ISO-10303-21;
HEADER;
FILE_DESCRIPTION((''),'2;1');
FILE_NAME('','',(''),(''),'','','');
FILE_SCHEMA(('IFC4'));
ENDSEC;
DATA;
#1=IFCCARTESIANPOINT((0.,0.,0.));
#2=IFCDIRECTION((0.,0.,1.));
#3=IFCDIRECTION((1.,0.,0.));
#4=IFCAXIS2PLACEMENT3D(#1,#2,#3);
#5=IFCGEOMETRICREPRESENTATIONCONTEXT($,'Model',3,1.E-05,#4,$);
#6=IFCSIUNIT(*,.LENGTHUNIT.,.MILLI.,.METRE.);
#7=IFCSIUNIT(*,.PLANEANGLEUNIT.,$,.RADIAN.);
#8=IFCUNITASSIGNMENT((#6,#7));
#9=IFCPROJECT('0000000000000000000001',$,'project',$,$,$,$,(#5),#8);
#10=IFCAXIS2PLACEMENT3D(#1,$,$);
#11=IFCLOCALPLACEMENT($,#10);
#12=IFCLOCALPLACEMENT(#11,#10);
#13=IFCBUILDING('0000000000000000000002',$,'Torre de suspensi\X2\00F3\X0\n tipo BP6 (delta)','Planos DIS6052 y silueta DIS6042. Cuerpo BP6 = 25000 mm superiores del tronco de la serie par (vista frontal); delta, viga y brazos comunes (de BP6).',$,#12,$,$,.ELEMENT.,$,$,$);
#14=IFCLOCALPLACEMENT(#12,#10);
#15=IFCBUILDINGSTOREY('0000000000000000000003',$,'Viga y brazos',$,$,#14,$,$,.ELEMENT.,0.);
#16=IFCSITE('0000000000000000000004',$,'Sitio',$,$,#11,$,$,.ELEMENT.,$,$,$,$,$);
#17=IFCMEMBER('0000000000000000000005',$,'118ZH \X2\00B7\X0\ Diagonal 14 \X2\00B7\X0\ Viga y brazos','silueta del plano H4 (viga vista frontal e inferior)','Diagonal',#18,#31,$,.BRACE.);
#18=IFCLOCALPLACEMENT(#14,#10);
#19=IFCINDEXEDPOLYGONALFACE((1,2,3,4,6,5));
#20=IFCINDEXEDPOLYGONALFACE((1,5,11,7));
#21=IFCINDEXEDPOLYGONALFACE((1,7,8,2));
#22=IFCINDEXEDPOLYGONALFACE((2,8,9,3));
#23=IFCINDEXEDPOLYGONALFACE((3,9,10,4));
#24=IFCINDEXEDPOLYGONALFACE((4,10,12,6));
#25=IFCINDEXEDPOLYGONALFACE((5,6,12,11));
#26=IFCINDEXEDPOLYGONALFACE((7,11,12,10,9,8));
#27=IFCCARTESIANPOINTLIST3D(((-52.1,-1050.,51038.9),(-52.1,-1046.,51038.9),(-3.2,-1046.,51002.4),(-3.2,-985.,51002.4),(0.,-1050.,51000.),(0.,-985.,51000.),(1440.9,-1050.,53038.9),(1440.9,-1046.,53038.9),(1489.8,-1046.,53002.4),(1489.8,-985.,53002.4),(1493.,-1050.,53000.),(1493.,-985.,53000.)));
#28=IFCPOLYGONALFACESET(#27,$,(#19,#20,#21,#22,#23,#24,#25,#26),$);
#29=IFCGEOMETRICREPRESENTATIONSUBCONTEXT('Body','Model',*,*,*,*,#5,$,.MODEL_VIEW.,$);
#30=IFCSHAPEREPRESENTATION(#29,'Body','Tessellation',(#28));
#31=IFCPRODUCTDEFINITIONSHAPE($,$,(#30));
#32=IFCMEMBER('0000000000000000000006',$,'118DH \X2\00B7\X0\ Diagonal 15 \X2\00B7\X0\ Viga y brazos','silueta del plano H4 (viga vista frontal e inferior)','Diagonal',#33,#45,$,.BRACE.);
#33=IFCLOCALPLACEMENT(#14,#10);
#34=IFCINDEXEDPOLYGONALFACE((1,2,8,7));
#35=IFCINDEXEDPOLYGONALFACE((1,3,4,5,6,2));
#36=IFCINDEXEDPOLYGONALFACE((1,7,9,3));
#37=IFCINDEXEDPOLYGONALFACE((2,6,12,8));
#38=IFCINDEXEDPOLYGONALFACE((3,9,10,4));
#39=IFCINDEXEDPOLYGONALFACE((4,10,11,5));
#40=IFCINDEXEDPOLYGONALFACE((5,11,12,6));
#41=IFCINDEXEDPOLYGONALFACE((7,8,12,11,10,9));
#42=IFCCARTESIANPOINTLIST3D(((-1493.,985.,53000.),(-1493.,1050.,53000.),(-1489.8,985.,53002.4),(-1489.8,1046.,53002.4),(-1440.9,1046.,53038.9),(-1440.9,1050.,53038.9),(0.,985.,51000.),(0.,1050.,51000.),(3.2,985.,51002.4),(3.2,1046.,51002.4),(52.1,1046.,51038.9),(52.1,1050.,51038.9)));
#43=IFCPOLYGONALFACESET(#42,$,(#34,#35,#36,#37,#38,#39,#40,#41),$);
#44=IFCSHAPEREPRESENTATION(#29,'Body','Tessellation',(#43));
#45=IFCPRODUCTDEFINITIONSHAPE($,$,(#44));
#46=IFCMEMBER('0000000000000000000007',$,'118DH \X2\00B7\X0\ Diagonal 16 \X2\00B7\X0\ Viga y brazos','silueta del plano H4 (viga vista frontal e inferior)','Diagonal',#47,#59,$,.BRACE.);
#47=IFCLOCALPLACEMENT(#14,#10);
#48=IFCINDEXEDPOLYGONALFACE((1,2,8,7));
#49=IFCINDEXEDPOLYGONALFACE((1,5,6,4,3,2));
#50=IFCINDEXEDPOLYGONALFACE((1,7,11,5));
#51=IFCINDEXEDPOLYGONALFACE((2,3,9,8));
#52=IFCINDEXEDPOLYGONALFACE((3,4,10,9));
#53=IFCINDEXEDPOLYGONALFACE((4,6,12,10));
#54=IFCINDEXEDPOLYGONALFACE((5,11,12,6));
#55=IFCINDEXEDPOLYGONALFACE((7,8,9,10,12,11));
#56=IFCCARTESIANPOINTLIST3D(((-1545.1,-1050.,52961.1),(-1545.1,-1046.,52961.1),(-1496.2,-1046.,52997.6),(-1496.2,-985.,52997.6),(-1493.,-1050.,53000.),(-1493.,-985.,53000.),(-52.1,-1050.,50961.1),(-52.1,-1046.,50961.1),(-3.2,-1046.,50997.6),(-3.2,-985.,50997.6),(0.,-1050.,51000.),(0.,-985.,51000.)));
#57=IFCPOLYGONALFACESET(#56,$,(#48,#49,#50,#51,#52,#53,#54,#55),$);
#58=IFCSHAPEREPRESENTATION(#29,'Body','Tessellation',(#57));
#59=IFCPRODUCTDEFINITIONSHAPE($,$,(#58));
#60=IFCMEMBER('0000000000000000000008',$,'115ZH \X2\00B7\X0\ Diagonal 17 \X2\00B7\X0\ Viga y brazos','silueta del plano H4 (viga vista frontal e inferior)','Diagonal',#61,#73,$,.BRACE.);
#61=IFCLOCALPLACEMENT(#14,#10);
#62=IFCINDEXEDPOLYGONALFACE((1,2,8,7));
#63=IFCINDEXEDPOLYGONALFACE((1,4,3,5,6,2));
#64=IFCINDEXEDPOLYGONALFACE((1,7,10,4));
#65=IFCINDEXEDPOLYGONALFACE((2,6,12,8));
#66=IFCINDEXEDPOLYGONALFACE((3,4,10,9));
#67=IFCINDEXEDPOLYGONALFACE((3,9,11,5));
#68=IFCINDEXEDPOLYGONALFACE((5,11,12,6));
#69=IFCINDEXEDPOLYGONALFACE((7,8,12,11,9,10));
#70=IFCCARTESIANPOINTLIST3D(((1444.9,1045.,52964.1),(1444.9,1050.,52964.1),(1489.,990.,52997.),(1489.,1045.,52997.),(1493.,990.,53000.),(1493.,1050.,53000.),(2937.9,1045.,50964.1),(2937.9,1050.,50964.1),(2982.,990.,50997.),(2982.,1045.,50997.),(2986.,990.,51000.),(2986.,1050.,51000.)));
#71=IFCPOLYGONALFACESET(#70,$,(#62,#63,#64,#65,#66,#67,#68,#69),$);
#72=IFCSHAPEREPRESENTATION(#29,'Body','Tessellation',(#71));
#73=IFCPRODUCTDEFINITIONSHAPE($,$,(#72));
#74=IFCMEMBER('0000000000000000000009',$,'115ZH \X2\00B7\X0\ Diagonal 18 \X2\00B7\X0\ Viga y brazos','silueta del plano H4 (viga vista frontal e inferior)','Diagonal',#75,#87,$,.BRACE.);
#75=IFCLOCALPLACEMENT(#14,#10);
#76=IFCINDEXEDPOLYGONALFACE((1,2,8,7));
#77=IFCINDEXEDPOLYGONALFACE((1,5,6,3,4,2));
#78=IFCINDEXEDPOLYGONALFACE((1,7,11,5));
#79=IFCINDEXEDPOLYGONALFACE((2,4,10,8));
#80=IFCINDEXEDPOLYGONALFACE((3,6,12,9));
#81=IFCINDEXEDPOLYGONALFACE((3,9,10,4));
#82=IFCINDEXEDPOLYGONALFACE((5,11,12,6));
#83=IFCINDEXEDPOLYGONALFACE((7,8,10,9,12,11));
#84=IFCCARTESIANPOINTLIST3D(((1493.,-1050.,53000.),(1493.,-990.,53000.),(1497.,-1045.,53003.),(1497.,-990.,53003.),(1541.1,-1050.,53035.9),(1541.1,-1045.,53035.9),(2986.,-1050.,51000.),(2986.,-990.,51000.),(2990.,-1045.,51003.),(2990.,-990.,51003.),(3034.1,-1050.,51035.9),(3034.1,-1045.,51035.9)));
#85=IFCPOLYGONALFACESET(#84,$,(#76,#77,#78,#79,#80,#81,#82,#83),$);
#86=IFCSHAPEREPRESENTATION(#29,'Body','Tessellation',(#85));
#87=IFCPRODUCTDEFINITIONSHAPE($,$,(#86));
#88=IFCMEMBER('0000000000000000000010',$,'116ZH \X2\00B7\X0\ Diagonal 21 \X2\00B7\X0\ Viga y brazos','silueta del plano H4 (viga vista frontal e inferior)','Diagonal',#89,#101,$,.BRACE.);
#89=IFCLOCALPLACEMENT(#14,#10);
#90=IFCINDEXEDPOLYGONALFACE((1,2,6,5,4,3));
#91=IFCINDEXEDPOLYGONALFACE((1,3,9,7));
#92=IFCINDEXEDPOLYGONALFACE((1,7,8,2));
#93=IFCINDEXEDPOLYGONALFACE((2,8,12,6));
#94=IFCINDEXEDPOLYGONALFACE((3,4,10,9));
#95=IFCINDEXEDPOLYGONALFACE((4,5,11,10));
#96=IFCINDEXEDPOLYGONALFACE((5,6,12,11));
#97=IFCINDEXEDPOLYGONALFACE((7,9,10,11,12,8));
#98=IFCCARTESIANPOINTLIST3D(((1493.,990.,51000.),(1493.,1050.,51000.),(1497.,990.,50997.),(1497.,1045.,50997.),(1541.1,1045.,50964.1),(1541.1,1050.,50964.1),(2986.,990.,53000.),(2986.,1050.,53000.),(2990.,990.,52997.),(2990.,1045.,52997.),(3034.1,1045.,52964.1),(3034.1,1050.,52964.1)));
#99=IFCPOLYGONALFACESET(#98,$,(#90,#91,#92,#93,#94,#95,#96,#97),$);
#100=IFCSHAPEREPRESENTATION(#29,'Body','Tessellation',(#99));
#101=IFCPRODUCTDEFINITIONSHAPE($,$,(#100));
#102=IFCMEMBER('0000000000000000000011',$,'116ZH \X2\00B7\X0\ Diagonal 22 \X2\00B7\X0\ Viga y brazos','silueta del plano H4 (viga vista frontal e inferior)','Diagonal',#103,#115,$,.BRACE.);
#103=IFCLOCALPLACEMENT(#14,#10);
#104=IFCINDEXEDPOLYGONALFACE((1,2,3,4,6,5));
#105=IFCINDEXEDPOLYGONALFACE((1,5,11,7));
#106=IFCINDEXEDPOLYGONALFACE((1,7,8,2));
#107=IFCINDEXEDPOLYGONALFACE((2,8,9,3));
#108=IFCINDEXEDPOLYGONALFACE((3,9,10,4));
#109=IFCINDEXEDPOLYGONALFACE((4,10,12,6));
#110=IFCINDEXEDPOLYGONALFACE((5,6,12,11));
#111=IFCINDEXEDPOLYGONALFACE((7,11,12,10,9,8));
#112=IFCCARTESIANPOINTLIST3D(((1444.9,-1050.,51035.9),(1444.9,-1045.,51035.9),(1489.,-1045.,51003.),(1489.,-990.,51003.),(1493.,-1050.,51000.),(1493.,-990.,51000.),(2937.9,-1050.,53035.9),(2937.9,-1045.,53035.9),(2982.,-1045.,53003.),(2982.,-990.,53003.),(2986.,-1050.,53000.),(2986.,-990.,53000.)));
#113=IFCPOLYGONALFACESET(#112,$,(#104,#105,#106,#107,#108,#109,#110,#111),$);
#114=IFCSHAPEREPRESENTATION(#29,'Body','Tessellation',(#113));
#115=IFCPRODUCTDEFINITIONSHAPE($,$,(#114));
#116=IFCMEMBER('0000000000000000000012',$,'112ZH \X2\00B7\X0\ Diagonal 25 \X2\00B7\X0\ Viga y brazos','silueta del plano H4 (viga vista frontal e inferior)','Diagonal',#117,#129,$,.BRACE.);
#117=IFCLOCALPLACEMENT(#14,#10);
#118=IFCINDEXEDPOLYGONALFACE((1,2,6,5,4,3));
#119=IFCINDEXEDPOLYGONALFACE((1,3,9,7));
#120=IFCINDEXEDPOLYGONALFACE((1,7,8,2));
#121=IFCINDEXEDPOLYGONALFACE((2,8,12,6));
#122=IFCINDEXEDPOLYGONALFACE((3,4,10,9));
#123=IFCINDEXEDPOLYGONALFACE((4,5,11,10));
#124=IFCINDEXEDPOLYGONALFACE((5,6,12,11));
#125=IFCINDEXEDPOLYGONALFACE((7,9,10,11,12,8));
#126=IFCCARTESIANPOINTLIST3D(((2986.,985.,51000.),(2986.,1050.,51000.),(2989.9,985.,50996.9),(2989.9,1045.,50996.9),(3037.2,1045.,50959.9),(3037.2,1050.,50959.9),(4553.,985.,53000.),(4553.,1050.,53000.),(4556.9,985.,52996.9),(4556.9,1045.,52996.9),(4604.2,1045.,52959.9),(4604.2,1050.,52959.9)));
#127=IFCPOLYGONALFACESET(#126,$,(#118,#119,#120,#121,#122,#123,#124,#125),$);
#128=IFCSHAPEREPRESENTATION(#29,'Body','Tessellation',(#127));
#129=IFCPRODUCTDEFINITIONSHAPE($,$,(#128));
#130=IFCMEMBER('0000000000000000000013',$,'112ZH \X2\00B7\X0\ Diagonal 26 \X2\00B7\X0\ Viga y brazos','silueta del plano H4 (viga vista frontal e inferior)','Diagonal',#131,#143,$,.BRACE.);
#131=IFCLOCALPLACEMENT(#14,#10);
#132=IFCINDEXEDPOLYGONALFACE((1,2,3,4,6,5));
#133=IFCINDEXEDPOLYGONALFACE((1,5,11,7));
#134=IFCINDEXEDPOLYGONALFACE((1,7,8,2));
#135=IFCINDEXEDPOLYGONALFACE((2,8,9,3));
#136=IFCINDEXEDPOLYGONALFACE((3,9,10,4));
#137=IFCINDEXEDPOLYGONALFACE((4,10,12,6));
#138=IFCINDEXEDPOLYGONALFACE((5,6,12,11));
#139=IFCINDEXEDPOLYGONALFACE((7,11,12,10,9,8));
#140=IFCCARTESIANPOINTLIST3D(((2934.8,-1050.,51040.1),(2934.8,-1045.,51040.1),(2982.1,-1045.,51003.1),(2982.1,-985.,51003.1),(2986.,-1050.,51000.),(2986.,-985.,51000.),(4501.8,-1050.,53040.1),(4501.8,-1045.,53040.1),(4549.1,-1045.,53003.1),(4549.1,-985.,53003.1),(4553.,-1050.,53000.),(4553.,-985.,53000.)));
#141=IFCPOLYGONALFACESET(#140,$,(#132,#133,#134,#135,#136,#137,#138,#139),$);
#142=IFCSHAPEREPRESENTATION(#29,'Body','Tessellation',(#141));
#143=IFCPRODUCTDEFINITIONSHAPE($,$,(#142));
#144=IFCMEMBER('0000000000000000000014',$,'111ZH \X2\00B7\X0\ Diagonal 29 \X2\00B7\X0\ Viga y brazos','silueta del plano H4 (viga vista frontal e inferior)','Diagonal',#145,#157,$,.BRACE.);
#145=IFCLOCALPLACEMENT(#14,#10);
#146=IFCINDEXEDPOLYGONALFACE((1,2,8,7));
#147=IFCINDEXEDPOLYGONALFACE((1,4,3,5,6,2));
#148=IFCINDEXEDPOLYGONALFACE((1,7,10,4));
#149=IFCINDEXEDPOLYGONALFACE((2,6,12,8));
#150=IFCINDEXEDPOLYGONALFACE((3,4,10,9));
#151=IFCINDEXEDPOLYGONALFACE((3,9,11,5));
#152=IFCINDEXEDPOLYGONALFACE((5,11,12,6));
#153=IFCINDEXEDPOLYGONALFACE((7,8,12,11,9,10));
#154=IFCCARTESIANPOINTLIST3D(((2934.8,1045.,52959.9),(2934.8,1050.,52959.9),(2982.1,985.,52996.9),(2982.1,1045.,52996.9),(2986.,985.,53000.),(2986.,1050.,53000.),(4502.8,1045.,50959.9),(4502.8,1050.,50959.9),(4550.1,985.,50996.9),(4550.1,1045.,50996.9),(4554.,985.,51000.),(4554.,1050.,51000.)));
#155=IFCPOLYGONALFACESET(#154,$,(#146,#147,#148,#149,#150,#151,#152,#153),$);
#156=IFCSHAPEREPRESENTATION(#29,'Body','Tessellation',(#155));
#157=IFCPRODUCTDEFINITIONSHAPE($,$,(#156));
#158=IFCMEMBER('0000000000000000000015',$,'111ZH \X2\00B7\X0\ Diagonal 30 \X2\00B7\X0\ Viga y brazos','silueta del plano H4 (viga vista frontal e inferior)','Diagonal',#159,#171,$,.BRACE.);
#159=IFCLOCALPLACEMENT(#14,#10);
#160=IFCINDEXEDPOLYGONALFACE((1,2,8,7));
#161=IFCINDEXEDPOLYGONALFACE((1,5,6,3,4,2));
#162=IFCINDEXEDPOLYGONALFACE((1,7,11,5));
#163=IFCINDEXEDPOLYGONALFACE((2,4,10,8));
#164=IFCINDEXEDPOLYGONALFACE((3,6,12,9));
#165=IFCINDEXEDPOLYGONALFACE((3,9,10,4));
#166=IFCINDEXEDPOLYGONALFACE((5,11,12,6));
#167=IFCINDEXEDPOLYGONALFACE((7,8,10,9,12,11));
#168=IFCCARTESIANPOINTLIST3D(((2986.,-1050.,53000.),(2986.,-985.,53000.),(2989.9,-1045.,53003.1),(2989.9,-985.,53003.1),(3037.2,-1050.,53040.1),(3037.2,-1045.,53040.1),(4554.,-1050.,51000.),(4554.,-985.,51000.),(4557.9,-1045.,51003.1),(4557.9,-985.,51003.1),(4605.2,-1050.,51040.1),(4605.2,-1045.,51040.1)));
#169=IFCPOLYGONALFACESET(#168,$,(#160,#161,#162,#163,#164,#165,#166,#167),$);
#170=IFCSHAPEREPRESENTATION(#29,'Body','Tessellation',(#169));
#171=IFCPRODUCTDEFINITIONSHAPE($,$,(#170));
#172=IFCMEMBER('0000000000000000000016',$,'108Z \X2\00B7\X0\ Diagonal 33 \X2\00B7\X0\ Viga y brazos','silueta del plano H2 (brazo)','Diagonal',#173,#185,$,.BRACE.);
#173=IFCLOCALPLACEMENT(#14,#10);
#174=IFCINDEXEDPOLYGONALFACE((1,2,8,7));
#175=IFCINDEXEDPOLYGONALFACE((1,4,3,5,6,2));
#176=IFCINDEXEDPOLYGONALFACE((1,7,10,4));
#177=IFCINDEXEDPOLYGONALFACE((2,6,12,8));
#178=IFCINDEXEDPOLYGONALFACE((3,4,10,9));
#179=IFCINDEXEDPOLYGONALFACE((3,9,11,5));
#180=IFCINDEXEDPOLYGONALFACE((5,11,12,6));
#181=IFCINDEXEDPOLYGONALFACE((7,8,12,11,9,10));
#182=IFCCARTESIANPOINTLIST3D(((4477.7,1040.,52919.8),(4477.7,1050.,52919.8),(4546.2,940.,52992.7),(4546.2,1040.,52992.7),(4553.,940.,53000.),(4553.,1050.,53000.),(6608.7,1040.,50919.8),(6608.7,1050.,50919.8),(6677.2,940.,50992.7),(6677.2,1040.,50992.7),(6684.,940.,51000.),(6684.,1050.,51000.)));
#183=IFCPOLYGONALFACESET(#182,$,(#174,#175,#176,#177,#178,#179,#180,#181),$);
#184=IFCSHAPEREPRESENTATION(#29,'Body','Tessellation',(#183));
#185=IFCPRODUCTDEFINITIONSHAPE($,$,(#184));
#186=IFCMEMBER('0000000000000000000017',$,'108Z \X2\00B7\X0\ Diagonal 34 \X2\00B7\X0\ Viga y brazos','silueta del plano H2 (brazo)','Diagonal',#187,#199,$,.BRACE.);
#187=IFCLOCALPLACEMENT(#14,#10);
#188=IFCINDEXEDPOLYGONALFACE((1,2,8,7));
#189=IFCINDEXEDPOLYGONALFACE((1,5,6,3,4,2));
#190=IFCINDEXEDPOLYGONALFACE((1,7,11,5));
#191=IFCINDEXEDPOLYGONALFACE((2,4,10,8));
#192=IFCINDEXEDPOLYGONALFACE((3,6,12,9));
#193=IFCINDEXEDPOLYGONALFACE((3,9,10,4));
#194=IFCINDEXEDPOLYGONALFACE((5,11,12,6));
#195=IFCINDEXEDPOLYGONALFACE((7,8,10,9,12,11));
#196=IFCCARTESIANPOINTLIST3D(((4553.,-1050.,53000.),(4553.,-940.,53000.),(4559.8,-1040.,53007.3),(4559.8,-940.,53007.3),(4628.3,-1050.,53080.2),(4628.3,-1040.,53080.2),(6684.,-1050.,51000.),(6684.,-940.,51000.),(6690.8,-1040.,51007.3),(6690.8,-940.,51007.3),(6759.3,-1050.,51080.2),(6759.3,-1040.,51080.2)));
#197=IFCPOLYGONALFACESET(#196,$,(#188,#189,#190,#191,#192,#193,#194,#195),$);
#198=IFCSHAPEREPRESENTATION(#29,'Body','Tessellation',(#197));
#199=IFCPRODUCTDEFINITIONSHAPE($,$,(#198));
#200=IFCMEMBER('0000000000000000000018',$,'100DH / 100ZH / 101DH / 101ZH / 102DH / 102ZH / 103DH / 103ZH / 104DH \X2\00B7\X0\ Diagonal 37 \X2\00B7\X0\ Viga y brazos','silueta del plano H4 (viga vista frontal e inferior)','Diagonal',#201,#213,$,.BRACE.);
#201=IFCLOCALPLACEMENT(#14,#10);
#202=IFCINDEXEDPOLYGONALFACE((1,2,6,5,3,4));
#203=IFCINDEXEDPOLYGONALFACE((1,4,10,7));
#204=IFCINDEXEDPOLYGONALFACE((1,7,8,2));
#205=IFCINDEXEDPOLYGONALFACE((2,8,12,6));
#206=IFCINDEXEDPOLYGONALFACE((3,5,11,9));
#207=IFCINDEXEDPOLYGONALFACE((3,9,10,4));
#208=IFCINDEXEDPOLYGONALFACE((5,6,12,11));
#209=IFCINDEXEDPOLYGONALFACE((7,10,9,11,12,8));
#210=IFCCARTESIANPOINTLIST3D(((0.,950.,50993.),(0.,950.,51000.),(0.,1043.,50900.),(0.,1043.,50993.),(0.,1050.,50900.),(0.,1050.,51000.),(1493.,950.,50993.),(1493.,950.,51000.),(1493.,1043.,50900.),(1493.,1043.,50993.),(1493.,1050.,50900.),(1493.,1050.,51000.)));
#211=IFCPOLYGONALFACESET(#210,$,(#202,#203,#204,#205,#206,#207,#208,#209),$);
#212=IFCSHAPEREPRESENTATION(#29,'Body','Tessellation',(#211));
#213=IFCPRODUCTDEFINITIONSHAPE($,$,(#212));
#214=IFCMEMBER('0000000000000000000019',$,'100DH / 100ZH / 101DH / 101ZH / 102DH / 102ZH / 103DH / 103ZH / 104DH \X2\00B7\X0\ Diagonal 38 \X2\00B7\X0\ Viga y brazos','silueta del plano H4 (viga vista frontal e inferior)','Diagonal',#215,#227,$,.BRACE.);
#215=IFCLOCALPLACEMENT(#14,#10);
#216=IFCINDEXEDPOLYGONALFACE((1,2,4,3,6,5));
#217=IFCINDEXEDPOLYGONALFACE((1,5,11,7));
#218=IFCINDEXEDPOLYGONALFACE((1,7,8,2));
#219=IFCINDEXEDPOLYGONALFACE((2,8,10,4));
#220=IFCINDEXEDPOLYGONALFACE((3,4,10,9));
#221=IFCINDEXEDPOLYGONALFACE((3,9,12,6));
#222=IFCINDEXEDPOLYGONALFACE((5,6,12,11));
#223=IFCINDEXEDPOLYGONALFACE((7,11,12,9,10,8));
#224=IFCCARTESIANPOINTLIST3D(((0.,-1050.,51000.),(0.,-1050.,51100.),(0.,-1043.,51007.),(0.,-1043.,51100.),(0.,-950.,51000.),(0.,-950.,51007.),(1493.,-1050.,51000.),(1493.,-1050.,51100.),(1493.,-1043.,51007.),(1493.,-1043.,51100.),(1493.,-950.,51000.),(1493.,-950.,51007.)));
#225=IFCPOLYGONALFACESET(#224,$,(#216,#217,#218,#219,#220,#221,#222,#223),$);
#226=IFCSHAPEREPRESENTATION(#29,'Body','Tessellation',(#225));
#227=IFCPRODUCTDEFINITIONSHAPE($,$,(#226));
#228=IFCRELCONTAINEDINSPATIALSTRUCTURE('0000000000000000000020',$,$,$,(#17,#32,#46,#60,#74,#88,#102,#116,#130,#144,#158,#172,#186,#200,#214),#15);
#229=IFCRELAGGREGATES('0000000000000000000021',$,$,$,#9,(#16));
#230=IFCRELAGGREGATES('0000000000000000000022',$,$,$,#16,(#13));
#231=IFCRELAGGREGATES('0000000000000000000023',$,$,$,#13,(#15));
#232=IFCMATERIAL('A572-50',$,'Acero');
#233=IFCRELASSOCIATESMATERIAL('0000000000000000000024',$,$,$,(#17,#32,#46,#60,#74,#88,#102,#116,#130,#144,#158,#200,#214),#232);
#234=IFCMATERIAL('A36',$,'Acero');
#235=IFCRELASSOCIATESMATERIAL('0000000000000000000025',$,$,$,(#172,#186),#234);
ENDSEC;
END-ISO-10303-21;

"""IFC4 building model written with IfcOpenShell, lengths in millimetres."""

from ifc_helpers import new_model, si_unit, frame, frame_2d, origin, origin_with_axes, place, context, subcontext, project, spatial, l_section, extrude, material, element, save


model = new_model("IFC4")

# Units and contexts
model_context = context("Model", 3, precision=1e-05, world=origin_with_axes())
body_context = subcontext(model_context, "Body", "Model", "MODEL_VIEW")
ifc_project = project(units=[si_unit("LENGTHUNIT", "METRE", prefix="MILLI"), si_unit("PLANEANGLEUNIT", "RADIAN")], contexts=[model_context])

# Site, building, storey
site_placement = place(None, origin())
site = spatial("IfcSite", under=ifc_project, at=site_placement, Name="Sitio", CompositionType="ELEMENT")
building_placement = place(site_placement, origin())
building = spatial("IfcBuilding", under=site, at=building_placement, Name="Torre de suspensión tipo BP6 (delta)", Description="Planos DIS6052 y silueta DIS6042. Cuerpo BP6 = 25000 mm superiores del tronco de la serie par (vista frontal); delta, viga y brazos comunes (de BP6).", CompositionType="ELEMENT")
storey_placement = place(building_placement, origin())
storey = spatial("IfcBuildingStorey", under=building, at=storey_placement, Name="Viga y brazos", CompositionType="ELEMENT", Elevation=0.0)

# Members
ifc_material_1 = material(Name="A572-50", Category="Acero")
for number, where, z_axis, x_axis, name in (
    (1, (0.0, -1050.0, 51000.0), (0.598203, 0.0, 0.801344), (0.0, 1.0, 0.0), "118ZH · Diagonal 14 · Viga y brazos"),
    (2, (0.0, 1050.0, 51000.0), (-0.598203, 0.0, 0.801344), (0.0, -1.0, 0.0), "118DH · Diagonal 15 · Viga y brazos"),
    (3, (0.0, -1050.0, 51000.0), (-0.598203, 0.0, 0.801344), (0.0, 1.0, 0.0), "118DH · Diagonal 16 · Viga y brazos"),
):
    element("IfcMember", number, at=place(storey_placement, frame(where, z_axis=z_axis, x_axis=x_axis)), inside=storey, material=ifc_material_1, Name=name, Description="silueta del plano H4 (viga vista frontal e inferior)", ObjectType="Diagonal", PredefinedType="BRACE", context=body_context, shape_type="SweptSolid", body=[
        extrude(l_section(Depth=65.0, Width=65.0, Thickness=4.0, at=frame_2d((32.5, 32.5))), None, (0.0, 0.0, 1.0), 2495.8),
    ])
for number, where, z_axis, x_axis, name in (
    (4, (1493.0, 1050.0, 53000.0), (0.598203, 0.0, -0.801344), (0.0, -1.0, 0.0), "115ZH · Diagonal 17 · Viga y brazos"),
    (5, (1493.0, -1050.0, 53000.0), (0.598203, 0.0, -0.801344), (0.0, 1.0, 0.0), "115ZH · Diagonal 18 · Viga y brazos"),
    (6, (1493.0, 1050.0, 51000.0), (0.598203, 0.0, 0.801344), (0.0, -1.0, 0.0), "116ZH · Diagonal 21 · Viga y brazos"),
    (7, (1493.0, -1050.0, 51000.0), (0.598203, 0.0, 0.801344), (0.0, 1.0, 0.0), "116ZH · Diagonal 22 · Viga y brazos"),
):
    element("IfcMember", number, at=place(storey_placement, frame(where, z_axis=z_axis, x_axis=x_axis)), inside=storey, material=ifc_material_1, Name=name, Description="silueta del plano H4 (viga vista frontal e inferior)", ObjectType="Diagonal", PredefinedType="BRACE", context=body_context, shape_type="SweptSolid", body=[
        extrude(l_section(Depth=60.0, Width=60.0, Thickness=5.0, at=frame_2d((30.0, 30.0))), None, (0.0, 0.0, 1.0), 2495.8),
    ])
for number, where, z_axis, x_axis, name in (
    (8, (2986.0, 1050.0, 51000.0), (0.616743, 0.0, 0.787164), (0.0, -1.0, 0.0), "112ZH · Diagonal 25 · Viga y brazos"),
    (9, (2986.0, -1050.0, 51000.0), (0.616743, 0.0, 0.787164), (0.0, 1.0, 0.0), "112ZH · Diagonal 26 · Viga y brazos"),
):
    element("IfcMember", number, at=place(storey_placement, frame(where, z_axis=z_axis, x_axis=x_axis)), inside=storey, material=ifc_material_1, Name=name, Description="silueta del plano H4 (viga vista frontal e inferior)", ObjectType="Diagonal", PredefinedType="BRACE", context=body_context, shape_type="SweptSolid", body=[
        extrude(l_section(Depth=65.0, Width=65.0, Thickness=5.0, at=frame_2d((32.5, 32.5))), None, (0.0, 0.0, 1.0), 2540.8),
    ])
for number, where, z_axis, x_axis, name in (
    (10, (2986.0, 1050.0, 53000.0), (0.616987, 0.0, -0.786973), (0.0, -1.0, 0.0), "111ZH · Diagonal 29 · Viga y brazos"),
    (11, (2986.0, -1050.0, 53000.0), (0.616987, 0.0, -0.786973), (0.0, 1.0, 0.0), "111ZH · Diagonal 30 · Viga y brazos"),
):
    element("IfcMember", number, at=place(storey_placement, frame(where, z_axis=z_axis, x_axis=x_axis)), inside=storey, material=ifc_material_1, Name=name, Description="silueta del plano H4 (viga vista frontal e inferior)", ObjectType="Diagonal", PredefinedType="BRACE", context=body_context, shape_type="SweptSolid", body=[
        extrude(l_section(Depth=65.0, Width=65.0, Thickness=5.0, at=frame_2d((32.5, 32.5))), None, (0.0, 0.0, 1.0), 2541.4),
    ])
ifc_material_2 = material(Name="A36", Category="Acero")
for number, where, z_axis, x_axis, name in (
    (12, (4553.0, 1050.0, 53000.0), (0.729164, 0.0, -0.684339), (0.0, -1.0, 0.0), "108Z · Diagonal 33 · Viga y brazos"),
    (13, (4553.0, -1050.0, 53000.0), (0.729164, 0.0, -0.684339), (0.0, 1.0, 0.0), "108Z · Diagonal 34 · Viga y brazos"),
):
    element("IfcMember", number, at=place(storey_placement, frame(where, z_axis=z_axis, x_axis=x_axis)), inside=storey, material=ifc_material_2, Name=name, Description="silueta del plano H2 (brazo)", ObjectType="Diagonal", PredefinedType="BRACE", context=body_context, shape_type="SweptSolid", body=[
        extrude(l_section(Depth=110.0, Width=110.0, Thickness=10.0, at=frame_2d((55.0, 55.0))), None, (0.0, 0.0, 1.0), 2922.5),
    ])
for number, where, z_axis, x_axis, name in (
    (14, (0.0, 1050.0, 51000.0), (1.0, 0.0, 0.0), (0.0, -1.0, 0.0), "100DH / 100ZH / 101DH / 101ZH / 102DH / 102ZH / 103DH / 103ZH / 104DH · Diagonal 37 · Viga y brazos"),
    (15, (0.0, -1050.0, 51000.0), (1.0, 0.0, 0.0), (0.0, 1.0, 0.0), "100DH / 100ZH / 101DH / 101ZH / 102DH / 102ZH / 103DH / 103ZH / 104DH · Diagonal 38 · Viga y brazos"),
):
    element("IfcMember", number, at=place(storey_placement, frame(where, z_axis=z_axis, x_axis=x_axis)), inside=storey, material=ifc_material_1, Name=name, Description="silueta del plano H4 (viga vista frontal e inferior)", ObjectType="Diagonal", PredefinedType="BRACE", context=body_context, shape_type="SweptSolid", body=[
        extrude(l_section(Depth=100.0, Width=100.0, Thickness=7.0, at=frame_2d((50.0, 50.0))), None, (0.0, 0.0, 1.0), 1493.0),
    ])

save(model, "model.ifc")
